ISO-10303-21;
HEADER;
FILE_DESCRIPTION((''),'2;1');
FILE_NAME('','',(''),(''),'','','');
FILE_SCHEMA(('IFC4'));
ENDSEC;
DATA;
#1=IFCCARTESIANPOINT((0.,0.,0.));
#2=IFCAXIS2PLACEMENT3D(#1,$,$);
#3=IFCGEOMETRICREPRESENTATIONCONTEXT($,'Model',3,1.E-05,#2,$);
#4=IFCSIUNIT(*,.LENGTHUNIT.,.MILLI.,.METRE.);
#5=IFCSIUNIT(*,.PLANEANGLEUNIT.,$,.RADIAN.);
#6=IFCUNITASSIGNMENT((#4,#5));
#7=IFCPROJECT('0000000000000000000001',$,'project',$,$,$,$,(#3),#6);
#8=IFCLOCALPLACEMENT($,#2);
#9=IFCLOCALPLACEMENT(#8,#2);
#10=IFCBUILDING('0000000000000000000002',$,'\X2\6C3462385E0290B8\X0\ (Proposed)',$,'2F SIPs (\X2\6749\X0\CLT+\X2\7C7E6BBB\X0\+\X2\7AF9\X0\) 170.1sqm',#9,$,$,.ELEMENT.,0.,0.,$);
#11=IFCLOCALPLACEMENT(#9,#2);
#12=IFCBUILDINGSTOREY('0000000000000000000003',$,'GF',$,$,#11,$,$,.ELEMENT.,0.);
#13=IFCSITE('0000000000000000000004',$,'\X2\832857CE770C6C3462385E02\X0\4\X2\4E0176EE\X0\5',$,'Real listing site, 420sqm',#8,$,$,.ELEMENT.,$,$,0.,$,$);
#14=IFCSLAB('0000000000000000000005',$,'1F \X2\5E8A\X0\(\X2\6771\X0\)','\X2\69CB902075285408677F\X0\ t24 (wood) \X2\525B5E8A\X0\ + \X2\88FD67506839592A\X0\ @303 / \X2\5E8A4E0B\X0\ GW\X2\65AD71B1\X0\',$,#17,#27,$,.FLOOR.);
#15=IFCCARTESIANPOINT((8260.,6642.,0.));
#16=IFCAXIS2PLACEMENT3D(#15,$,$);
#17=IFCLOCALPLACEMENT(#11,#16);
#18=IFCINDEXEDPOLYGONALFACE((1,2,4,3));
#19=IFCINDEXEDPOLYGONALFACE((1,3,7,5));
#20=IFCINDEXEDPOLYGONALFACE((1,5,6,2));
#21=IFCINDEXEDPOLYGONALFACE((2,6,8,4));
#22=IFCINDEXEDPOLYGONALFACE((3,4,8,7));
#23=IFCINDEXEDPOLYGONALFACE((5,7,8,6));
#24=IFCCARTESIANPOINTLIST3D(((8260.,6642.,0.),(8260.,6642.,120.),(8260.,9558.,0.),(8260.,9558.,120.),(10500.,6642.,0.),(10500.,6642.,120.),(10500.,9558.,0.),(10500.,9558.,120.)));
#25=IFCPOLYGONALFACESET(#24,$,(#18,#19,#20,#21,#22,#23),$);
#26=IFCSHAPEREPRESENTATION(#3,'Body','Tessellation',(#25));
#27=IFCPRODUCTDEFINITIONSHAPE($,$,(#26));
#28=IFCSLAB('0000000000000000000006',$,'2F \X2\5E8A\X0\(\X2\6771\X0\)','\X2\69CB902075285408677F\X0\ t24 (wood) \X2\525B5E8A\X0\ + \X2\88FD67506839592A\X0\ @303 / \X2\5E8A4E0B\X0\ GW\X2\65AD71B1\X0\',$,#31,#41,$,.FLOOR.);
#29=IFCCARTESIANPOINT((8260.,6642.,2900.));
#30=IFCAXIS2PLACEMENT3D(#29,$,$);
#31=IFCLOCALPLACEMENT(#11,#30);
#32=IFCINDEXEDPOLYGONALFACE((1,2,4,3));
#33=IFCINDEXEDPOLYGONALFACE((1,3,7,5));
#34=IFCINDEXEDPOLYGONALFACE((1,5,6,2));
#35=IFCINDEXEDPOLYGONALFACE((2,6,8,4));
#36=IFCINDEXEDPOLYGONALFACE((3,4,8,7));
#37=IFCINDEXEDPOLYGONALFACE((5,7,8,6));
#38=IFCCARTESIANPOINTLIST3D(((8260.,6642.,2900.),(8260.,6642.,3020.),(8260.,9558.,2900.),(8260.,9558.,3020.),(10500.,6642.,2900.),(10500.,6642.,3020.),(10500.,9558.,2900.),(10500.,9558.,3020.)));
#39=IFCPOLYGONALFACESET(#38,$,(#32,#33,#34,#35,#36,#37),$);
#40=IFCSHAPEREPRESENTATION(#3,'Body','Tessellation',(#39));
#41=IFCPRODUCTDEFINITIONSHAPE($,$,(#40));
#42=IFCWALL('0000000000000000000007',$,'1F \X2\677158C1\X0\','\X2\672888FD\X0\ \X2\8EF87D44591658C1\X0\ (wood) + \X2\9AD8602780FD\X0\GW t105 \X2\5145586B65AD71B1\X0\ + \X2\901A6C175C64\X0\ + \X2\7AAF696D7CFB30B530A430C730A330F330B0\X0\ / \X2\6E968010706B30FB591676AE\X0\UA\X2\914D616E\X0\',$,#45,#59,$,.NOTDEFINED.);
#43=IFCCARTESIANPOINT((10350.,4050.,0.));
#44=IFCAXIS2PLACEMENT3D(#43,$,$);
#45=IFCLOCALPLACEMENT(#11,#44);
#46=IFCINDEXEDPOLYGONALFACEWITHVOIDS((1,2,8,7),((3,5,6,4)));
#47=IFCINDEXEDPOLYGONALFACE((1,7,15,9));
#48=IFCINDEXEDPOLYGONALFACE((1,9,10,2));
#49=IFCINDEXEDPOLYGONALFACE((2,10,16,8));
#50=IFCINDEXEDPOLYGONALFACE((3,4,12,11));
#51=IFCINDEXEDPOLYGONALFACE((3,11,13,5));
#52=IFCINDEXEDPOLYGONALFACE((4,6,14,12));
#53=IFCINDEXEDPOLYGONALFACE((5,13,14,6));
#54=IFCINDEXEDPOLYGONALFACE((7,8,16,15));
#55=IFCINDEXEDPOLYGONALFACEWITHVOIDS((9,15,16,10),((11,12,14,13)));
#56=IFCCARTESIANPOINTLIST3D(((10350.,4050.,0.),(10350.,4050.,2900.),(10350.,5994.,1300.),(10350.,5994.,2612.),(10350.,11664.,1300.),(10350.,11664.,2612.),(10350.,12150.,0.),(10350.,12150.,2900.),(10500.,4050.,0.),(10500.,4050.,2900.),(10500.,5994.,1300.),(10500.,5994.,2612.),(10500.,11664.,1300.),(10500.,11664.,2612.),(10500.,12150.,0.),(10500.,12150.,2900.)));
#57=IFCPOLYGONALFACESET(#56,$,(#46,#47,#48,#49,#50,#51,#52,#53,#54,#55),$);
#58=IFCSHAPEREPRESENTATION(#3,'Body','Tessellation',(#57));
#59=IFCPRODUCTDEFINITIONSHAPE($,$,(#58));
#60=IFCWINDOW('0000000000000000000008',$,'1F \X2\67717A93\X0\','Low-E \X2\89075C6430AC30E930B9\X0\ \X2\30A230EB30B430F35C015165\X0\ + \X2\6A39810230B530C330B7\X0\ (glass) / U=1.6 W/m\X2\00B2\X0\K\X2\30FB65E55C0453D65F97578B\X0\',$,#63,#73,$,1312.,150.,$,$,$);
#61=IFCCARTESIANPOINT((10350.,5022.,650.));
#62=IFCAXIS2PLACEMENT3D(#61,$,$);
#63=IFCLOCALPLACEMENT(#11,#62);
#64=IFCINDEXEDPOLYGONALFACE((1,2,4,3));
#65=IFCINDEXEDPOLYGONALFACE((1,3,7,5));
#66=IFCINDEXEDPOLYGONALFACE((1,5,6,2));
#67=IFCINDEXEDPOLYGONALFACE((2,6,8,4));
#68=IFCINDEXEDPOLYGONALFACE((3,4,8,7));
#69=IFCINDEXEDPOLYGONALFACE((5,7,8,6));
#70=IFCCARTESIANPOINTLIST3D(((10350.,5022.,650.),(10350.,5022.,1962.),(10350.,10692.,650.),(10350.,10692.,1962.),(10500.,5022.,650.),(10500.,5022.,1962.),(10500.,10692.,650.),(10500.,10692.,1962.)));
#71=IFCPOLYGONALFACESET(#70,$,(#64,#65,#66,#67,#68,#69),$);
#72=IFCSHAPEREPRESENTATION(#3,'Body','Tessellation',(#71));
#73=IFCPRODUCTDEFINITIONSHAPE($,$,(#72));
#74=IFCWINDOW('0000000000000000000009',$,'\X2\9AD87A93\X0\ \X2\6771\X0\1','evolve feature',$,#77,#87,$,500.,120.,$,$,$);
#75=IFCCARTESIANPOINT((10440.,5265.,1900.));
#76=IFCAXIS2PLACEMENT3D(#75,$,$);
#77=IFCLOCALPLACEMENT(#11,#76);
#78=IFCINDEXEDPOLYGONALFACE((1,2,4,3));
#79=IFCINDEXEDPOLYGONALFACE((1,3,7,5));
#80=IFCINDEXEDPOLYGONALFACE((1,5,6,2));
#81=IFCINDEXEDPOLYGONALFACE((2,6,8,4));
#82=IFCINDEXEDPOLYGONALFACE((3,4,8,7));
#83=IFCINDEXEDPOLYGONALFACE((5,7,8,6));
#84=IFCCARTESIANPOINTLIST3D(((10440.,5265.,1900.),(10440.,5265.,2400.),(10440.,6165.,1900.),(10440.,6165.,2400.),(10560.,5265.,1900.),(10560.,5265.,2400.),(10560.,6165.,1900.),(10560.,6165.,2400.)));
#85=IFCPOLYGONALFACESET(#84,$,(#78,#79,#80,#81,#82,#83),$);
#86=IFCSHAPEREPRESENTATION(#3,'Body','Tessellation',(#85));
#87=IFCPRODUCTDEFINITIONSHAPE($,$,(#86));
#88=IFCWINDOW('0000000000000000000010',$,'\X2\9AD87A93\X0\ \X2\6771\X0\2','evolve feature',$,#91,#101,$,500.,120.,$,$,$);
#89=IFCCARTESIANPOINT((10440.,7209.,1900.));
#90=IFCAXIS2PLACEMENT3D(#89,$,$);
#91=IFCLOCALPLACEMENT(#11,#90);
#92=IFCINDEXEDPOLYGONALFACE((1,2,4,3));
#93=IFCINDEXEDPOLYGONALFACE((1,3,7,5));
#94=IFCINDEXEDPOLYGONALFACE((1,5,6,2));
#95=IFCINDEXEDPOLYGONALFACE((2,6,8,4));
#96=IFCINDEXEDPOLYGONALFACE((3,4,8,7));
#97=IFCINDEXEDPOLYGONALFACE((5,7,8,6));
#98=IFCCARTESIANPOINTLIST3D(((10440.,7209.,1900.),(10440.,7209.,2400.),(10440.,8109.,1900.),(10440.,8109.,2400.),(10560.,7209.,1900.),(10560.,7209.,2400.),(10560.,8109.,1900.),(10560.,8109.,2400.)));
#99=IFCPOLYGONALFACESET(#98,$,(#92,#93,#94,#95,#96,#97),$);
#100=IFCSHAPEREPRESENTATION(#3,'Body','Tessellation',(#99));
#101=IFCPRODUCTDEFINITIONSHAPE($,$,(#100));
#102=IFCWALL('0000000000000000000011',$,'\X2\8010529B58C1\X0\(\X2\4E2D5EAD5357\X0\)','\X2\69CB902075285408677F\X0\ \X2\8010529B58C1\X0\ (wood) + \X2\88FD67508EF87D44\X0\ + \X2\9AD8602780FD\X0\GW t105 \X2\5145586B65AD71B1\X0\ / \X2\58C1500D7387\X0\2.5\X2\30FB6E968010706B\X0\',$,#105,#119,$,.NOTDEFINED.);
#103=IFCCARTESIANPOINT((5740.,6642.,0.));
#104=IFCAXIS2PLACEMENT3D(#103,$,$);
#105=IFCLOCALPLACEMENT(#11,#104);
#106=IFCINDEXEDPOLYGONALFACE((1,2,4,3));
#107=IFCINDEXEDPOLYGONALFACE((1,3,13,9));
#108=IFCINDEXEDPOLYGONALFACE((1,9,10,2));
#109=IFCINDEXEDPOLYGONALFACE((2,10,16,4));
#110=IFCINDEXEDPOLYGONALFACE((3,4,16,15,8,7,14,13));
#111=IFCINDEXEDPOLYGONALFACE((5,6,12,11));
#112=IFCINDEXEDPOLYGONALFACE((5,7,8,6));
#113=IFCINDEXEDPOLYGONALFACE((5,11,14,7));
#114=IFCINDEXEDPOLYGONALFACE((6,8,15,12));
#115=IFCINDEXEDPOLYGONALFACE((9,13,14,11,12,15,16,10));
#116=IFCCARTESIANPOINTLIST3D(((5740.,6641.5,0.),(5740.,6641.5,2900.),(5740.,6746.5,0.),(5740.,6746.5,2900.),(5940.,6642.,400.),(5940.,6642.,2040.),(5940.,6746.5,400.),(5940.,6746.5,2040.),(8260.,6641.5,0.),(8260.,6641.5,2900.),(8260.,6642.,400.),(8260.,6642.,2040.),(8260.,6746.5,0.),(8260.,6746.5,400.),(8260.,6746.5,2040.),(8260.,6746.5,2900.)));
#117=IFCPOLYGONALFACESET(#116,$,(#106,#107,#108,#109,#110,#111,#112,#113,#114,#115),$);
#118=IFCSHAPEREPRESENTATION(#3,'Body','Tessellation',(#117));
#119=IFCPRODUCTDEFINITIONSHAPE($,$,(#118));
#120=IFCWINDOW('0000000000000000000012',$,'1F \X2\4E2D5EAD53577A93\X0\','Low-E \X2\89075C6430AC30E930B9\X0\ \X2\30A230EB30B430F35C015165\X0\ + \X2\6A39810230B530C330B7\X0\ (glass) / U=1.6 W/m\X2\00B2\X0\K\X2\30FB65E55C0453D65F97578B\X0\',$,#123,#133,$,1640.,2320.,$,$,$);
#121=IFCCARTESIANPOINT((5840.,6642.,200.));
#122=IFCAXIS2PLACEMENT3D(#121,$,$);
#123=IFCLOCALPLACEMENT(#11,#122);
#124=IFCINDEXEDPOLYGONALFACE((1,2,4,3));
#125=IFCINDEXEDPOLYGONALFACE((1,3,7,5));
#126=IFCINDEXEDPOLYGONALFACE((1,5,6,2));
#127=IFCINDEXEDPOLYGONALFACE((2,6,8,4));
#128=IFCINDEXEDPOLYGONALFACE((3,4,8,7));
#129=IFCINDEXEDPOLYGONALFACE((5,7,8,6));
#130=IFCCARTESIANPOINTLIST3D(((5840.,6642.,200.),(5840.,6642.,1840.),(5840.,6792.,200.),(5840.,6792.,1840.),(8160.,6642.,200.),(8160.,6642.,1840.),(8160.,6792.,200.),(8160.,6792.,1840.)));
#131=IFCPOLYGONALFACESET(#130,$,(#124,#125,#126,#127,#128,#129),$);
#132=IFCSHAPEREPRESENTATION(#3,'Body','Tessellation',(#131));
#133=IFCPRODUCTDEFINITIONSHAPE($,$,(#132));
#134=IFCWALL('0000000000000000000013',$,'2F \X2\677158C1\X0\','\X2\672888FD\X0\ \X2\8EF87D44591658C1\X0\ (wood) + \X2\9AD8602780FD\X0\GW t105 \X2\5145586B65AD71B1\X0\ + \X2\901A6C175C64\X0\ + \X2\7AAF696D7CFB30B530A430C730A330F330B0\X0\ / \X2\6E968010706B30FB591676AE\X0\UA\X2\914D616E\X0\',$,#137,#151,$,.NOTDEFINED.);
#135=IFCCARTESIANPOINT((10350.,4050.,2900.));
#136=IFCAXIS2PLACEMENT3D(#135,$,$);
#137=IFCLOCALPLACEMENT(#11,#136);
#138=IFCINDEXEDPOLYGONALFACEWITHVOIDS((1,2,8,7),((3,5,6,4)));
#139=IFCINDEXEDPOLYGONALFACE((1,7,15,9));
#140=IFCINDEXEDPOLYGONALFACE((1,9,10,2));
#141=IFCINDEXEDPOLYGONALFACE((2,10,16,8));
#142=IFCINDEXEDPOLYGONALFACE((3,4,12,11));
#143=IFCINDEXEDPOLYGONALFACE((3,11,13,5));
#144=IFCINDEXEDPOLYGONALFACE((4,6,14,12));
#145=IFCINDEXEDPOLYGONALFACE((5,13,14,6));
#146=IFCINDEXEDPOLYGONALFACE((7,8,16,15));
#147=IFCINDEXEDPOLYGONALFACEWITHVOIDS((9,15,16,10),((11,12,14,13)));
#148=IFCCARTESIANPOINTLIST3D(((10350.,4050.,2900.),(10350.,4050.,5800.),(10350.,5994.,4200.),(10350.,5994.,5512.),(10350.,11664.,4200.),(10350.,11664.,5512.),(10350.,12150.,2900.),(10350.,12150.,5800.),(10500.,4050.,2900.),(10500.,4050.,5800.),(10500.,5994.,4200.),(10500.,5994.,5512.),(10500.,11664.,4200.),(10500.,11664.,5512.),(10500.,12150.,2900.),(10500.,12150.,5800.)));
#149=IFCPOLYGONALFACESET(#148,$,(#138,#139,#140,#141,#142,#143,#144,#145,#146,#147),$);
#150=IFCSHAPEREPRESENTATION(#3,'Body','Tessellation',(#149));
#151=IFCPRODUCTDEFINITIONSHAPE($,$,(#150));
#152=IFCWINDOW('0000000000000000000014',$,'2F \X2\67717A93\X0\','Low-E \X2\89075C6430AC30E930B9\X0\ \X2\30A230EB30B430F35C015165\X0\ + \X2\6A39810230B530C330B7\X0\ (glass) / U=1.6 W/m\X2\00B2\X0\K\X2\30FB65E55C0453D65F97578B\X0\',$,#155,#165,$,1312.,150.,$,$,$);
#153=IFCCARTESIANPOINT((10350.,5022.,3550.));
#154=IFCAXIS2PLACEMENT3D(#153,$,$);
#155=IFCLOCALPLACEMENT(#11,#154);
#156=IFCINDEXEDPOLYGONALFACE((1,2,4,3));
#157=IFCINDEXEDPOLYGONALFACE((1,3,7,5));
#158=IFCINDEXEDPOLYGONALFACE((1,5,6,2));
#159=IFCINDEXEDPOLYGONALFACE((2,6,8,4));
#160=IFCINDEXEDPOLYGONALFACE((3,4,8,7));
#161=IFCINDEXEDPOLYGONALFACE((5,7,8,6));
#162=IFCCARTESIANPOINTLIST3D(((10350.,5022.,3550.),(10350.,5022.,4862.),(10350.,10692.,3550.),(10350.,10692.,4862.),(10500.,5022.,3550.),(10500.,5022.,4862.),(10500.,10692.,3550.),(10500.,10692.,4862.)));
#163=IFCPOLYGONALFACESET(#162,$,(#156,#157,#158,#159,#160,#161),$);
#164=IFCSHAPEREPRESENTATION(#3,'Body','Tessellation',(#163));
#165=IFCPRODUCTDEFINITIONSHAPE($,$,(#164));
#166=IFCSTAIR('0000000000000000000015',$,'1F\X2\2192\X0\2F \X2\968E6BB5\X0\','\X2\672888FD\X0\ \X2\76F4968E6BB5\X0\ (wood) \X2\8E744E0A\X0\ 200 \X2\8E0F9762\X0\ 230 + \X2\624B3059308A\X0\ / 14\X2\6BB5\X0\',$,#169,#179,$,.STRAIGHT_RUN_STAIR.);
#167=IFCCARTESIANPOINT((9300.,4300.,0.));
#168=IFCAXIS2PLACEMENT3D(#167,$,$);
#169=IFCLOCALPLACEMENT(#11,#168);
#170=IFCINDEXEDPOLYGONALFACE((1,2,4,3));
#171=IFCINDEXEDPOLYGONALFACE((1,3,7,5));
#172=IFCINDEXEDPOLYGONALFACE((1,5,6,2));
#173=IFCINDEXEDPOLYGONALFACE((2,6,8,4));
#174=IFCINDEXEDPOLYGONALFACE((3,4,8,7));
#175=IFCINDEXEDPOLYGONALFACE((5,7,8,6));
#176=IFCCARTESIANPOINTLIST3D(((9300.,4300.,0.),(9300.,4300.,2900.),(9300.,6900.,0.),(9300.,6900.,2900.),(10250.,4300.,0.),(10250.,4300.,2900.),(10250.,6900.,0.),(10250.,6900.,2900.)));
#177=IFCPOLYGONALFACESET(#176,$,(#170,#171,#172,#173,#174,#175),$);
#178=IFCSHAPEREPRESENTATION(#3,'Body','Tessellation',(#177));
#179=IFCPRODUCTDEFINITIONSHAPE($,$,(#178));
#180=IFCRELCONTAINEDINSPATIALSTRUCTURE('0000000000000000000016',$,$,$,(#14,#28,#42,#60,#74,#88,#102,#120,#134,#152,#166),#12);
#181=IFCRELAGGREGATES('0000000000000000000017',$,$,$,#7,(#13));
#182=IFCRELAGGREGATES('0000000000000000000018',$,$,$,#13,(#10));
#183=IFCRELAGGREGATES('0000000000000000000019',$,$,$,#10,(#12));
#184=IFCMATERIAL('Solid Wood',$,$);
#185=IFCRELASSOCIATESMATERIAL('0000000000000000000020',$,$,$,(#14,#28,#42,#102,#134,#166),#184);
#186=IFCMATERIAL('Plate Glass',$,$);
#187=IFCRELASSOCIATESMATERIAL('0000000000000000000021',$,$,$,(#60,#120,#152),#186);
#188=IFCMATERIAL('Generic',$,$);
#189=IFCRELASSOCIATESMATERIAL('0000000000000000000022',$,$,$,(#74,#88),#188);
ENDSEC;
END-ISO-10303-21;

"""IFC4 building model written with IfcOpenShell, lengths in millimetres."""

from ifc_helpers import new_model, si_unit, frame, frame_2d, origin, place, context, project, spatial, rectangle, extrude, material, element, fill, save


model = new_model("IFC4")

# Units and contexts
model_context = context("Model", 3, precision=1e-05, world=origin())
ifc_project = project(units=[si_unit("LENGTHUNIT", "METRE", prefix="MILLI"), si_unit("PLANEANGLEUNIT", "RADIAN")], contexts=[model_context])

# Site, building, storey
site_placement = place(None, origin())
site = spatial("IfcSite", under=ifc_project, at=site_placement, Name="茨城県水戸市4丁目5", ObjectType="Real listing site, 420sqm", CompositionType="ELEMENT", RefElevation=0.0)
building_placement = place(site_placement, origin())
building = spatial("IfcBuilding", under=site, at=building_placement, Name="水戸市邸 (Proposed)", ObjectType="2F SIPs (杉CLT+籾殻+竹) 170.1sqm", CompositionType="ELEMENT", ElevationOfRefHeight=0.0, ElevationOfTerrain=0.0)
storey_placement = place(building_placement, origin())
storey = spatial("IfcBuildingStorey", under=building, at=storey_placement, Name="GF", CompositionType="ELEMENT", Elevation=0.0)

# Slabs
ifc_material_1 = material(Name="Solid Wood")
slab_1_placement = place(storey_placement, frame((8260.0, 6642.0, 0.0)))
element("IfcSlab", 1, at=slab_1_placement, inside=storey, material=ifc_material_1, Name="1F 床(東)", Description="構造用合板 t24 (wood) 剛床 + 製材根太 @303 / 床下 GW断熱", PredefinedType="FLOOR", context=model_context, shape_type="SweptSolid", body=[
    extrude(rectangle(XDim=2240.0, YDim=2916.0, at=frame_2d((1120.0, 1458.0))), frame((8260.0, 6642.0, 0.0)), (0.0, 0.0, 1.0), 120.0),
])
slab_2_placement = place(storey_placement, frame((8260.0, 6642.0, 2900.0)))
element("IfcSlab", 2, at=slab_2_placement, inside=storey, material=ifc_material_1, Name="2F 床(東)", Description="構造用合板 t24 (wood) 剛床 + 製材根太 @303 / 床下 GW断熱", PredefinedType="FLOOR", context=model_context, shape_type="SweptSolid", body=[
    extrude(rectangle(XDim=2240.0, YDim=2916.0, at=frame_2d((1120.0, 1458.0))), frame((8260.0, 6642.0, 2900.0)), (0.0, 0.0, 1.0), 120.0),
])

# Wall, openings, windows
wall_1_placement = place(storey_placement, frame((10350.0, 4050.0, 0.0)))
wall_1 = element("IfcWall", 3, at=wall_1_placement, inside=storey, material=ifc_material_1, Name="1F 東壁", Description="木製 軸組外壁 (wood) + 高性能GW t105 充填断熱 + 通気層 + 窯業系サイディング / 準耐火・外皮UA配慮", PredefinedType="NOTDEFINED", context=model_context, shape_type="SweptSolid", body=[
    extrude(rectangle(XDim=150.0, YDim=8100.0, at=frame_2d((75.0, 4050.0))), frame((10350.0, 4050.0, 0.0)), (0.0, 0.0, 1.0), 2900.0),
])
opening_1_placement = place(storey_placement, frame((10350.0, 5022.0, 650.0)))
opening_1 = element("IfcOpeningElement", 4, at=opening_1_placement, cuts=wall_1, PredefinedType="NOTDEFINED", context=model_context, shape_type="SweptSolid", body=[
    extrude(rectangle(XDim=150.0, YDim=5670.0, at=frame_2d((75.0, 2835.0))), frame((10350.0, 5022.0, 650.0)), (0.0, 0.0, 1.0), 1312.0),
])
opening_2_placement = place(storey_placement, frame((10440.0, 5265.0, 1900.0)))
opening_2 = element("IfcOpeningElement", 5, at=opening_2_placement, cuts=wall_1, PredefinedType="NOTDEFINED", context=model_context, shape_type="SweptSolid", body=[
    extrude(rectangle(XDim=120.0, YDim=900.0, at=frame_2d((60.0, 450.0))), frame((10440.0, 5265.0, 1900.0)), (0.0, 0.0, 1.0), 500.0),
])
opening_3_placement = place(storey_placement, frame((10440.0, 7209.0, 1900.0)))
opening_3 = element("IfcOpeningElement", 6, at=opening_3_placement, cuts=wall_1, PredefinedType="NOTDEFINED", context=model_context, shape_type="SweptSolid", body=[
    extrude(rectangle(XDim=120.0, YDim=900.0, at=frame_2d((60.0, 450.0))), frame((10440.0, 7209.0, 1900.0)), (0.0, 0.0, 1.0), 500.0),
])
ifc_material_2 = material(Name="Plate Glass")
window_1_placement = place(storey_placement, frame((10350.0, 5022.0, 650.0)))
window_1 = element("IfcWindow", 7, at=window_1_placement, inside=storey, material=ifc_material_2, Name="1F 東窓", Description="Low-E 複層ガラス アルゴン封入 + 樹脂サッシ (glass) / U=1.6 W/m²K・日射取得型", OverallHeight=1312.0, OverallWidth=150.0, context=model_context, shape_type="SweptSolid", body=[
    extrude(rectangle(XDim=150.0, YDim=5670.0, at=frame_2d((75.0, 2835.0))), frame((10350.0, 5022.0, 650.0)), (0.0, 0.0, 1.0), 1312.0),
])
fill(opening_1, window_1)
ifc_material_3 = material(Name="Generic")
window_2_placement = place(storey_placement, frame((10440.0, 5265.0, 1900.0)))
window_2 = element("IfcWindow", 8, at=window_2_placement, inside=storey, material=ifc_material_3, Name="高窓 東1", Description="evolve feature", OverallHeight=500.0, OverallWidth=120.0, context=model_context, shape_type="SweptSolid", body=[
    extrude(rectangle(XDim=120.0, YDim=900.0, at=frame_2d((60.0, 450.0))), frame((10440.0, 5265.0, 1900.0)), (0.0, 0.0, 1.0), 500.0),
])
fill(opening_2, window_2)
window_3_placement = place(storey_placement, frame((10440.0, 7209.0, 1900.0)))
window_3 = element("IfcWindow", 9, at=window_3_placement, inside=storey, material=ifc_material_3, Name="高窓 東2", Description="evolve feature", OverallHeight=500.0, OverallWidth=120.0, context=model_context, shape_type="SweptSolid", body=[
    extrude(rectangle(XDim=120.0, YDim=900.0, at=frame_2d((60.0, 450.0))), frame((10440.0, 7209.0, 1900.0)), (0.0, 0.0, 1.0), 500.0),
])
fill(opening_3, window_3)

# Wall, opening, window
wall_2_placement = place(storey_placement, frame((5740.0, 6642.0, 0.0)))
wall_2 = element("IfcWall", 10, at=wall_2_placement, inside=storey, material=ifc_material_1, Name="耐力壁(中庭南)", Description="構造用合板 耐力壁 (wood) + 製材軸組 + 高性能GW t105 充填断熱 / 壁倍率2.5・準耐火", PredefinedType="NOTDEFINED", context=model_context, shape_type="SweptSolid", body=[
    extrude(rectangle(XDim=2520.0, YDim=105.0, at=frame_2d((1260.0, 52.0))), frame((5740.0, 6642.0, 0.0)), (0.0, 0.0, 1.0), 2900.0),
])
opening_4_placement = place(storey_placement, frame((5840.0, 6642.0, 200.0)))
opening_4 = element("IfcOpeningElement", 11, at=opening_4_placement, cuts=wall_2, PredefinedType="NOTDEFINED", context=model_context, shape_type="SweptSolid", body=[
    extrude(rectangle(XDim=2320.0, YDim=150.0, at=frame_2d((1160.0, 75.0))), frame((5840.0, 6642.0, 200.0)), (0.0, 0.0, 1.0), 1640.0),
])
window_4_placement = place(storey_placement, frame((5840.0, 6642.0, 200.0)))
window_4 = element("IfcWindow", 12, at=window_4_placement, inside=storey, material=ifc_material_2, Name="1F 中庭南窓", Description="Low-E 複層ガラス アルゴン封入 + 樹脂サッシ (glass) / U=1.6 W/m²K・日射取得型", OverallHeight=1640.0, OverallWidth=2320.0, context=model_context, shape_type="SweptSolid", body=[
    extrude(rectangle(XDim=2320.0, YDim=150.0, at=frame_2d((1160.0, 75.0))), frame((5840.0, 6642.0, 200.0)), (0.0, 0.0, 1.0), 1640.0),
])
fill(opening_4, window_4)

# Wall, opening, window
wall_3_placement = place(storey_placement, frame((10350.0, 4050.0, 2900.0)))
wall_3 = element("IfcWall", 13, at=wall_3_placement, inside=storey, material=ifc_material_1, Name="2F 東壁", Description="木製 軸組外壁 (wood) + 高性能GW t105 充填断熱 + 通気層 + 窯業系サイディング / 準耐火・外皮UA配慮", PredefinedType="NOTDEFINED", context=model_context, shape_type="SweptSolid", body=[
    extrude(rectangle(XDim=150.0, YDim=8100.0, at=frame_2d((75.0, 4050.0))), frame((10350.0, 4050.0, 2900.0)), (0.0, 0.0, 1.0), 2900.0),
])
opening_5_placement = place(storey_placement, frame((10350.0, 5022.0, 3550.0)))
opening_5 = element("IfcOpeningElement", 14, at=opening_5_placement, cuts=wall_3, PredefinedType="NOTDEFINED", context=model_context, shape_type="SweptSolid", body=[
    extrude(rectangle(XDim=150.0, YDim=5670.0, at=frame_2d((75.0, 2835.0))), frame((10350.0, 5022.0, 3550.0)), (0.0, 0.0, 1.0), 1312.0),
])
window_5_placement = place(storey_placement, frame((10350.0, 5022.0, 3550.0)))
window_5 = element("IfcWindow", 15, at=window_5_placement, inside=storey, material=ifc_material_2, Name="2F 東窓", Description="Low-E 複層ガラス アルゴン封入 + 樹脂サッシ (glass) / U=1.6 W/m²K・日射取得型", OverallHeight=1312.0, OverallWidth=150.0, context=model_context, shape_type="SweptSolid", body=[
    extrude(rectangle(XDim=150.0, YDim=5670.0, at=frame_2d((75.0, 2835.0))), frame((10350.0, 5022.0, 3550.0)), (0.0, 0.0, 1.0), 1312.0),
])
fill(opening_5, window_5)

# Stair
stair_placement = place(storey_placement, frame((9300.0, 4300.0, 0.0)))
element("IfcStair", 16, at=stair_placement, inside=storey, material=ifc_material_1, Name="1F→2F 階段", Description="木製 直階段 (wood) 蹴上 200 踏面 230 + 手すり / 14段", PredefinedType="STRAIGHT_RUN_STAIR", context=model_context, shape_type="SweptSolid", body=[
    extrude(rectangle(XDim=950.0, YDim=2600.0, at=frame_2d((475.0, 1300.0))), frame((9300.0, 4300.0, 0.0)), (0.0, 0.0, 1.0), 2900.0),
])

save(model, "model.ifc")
